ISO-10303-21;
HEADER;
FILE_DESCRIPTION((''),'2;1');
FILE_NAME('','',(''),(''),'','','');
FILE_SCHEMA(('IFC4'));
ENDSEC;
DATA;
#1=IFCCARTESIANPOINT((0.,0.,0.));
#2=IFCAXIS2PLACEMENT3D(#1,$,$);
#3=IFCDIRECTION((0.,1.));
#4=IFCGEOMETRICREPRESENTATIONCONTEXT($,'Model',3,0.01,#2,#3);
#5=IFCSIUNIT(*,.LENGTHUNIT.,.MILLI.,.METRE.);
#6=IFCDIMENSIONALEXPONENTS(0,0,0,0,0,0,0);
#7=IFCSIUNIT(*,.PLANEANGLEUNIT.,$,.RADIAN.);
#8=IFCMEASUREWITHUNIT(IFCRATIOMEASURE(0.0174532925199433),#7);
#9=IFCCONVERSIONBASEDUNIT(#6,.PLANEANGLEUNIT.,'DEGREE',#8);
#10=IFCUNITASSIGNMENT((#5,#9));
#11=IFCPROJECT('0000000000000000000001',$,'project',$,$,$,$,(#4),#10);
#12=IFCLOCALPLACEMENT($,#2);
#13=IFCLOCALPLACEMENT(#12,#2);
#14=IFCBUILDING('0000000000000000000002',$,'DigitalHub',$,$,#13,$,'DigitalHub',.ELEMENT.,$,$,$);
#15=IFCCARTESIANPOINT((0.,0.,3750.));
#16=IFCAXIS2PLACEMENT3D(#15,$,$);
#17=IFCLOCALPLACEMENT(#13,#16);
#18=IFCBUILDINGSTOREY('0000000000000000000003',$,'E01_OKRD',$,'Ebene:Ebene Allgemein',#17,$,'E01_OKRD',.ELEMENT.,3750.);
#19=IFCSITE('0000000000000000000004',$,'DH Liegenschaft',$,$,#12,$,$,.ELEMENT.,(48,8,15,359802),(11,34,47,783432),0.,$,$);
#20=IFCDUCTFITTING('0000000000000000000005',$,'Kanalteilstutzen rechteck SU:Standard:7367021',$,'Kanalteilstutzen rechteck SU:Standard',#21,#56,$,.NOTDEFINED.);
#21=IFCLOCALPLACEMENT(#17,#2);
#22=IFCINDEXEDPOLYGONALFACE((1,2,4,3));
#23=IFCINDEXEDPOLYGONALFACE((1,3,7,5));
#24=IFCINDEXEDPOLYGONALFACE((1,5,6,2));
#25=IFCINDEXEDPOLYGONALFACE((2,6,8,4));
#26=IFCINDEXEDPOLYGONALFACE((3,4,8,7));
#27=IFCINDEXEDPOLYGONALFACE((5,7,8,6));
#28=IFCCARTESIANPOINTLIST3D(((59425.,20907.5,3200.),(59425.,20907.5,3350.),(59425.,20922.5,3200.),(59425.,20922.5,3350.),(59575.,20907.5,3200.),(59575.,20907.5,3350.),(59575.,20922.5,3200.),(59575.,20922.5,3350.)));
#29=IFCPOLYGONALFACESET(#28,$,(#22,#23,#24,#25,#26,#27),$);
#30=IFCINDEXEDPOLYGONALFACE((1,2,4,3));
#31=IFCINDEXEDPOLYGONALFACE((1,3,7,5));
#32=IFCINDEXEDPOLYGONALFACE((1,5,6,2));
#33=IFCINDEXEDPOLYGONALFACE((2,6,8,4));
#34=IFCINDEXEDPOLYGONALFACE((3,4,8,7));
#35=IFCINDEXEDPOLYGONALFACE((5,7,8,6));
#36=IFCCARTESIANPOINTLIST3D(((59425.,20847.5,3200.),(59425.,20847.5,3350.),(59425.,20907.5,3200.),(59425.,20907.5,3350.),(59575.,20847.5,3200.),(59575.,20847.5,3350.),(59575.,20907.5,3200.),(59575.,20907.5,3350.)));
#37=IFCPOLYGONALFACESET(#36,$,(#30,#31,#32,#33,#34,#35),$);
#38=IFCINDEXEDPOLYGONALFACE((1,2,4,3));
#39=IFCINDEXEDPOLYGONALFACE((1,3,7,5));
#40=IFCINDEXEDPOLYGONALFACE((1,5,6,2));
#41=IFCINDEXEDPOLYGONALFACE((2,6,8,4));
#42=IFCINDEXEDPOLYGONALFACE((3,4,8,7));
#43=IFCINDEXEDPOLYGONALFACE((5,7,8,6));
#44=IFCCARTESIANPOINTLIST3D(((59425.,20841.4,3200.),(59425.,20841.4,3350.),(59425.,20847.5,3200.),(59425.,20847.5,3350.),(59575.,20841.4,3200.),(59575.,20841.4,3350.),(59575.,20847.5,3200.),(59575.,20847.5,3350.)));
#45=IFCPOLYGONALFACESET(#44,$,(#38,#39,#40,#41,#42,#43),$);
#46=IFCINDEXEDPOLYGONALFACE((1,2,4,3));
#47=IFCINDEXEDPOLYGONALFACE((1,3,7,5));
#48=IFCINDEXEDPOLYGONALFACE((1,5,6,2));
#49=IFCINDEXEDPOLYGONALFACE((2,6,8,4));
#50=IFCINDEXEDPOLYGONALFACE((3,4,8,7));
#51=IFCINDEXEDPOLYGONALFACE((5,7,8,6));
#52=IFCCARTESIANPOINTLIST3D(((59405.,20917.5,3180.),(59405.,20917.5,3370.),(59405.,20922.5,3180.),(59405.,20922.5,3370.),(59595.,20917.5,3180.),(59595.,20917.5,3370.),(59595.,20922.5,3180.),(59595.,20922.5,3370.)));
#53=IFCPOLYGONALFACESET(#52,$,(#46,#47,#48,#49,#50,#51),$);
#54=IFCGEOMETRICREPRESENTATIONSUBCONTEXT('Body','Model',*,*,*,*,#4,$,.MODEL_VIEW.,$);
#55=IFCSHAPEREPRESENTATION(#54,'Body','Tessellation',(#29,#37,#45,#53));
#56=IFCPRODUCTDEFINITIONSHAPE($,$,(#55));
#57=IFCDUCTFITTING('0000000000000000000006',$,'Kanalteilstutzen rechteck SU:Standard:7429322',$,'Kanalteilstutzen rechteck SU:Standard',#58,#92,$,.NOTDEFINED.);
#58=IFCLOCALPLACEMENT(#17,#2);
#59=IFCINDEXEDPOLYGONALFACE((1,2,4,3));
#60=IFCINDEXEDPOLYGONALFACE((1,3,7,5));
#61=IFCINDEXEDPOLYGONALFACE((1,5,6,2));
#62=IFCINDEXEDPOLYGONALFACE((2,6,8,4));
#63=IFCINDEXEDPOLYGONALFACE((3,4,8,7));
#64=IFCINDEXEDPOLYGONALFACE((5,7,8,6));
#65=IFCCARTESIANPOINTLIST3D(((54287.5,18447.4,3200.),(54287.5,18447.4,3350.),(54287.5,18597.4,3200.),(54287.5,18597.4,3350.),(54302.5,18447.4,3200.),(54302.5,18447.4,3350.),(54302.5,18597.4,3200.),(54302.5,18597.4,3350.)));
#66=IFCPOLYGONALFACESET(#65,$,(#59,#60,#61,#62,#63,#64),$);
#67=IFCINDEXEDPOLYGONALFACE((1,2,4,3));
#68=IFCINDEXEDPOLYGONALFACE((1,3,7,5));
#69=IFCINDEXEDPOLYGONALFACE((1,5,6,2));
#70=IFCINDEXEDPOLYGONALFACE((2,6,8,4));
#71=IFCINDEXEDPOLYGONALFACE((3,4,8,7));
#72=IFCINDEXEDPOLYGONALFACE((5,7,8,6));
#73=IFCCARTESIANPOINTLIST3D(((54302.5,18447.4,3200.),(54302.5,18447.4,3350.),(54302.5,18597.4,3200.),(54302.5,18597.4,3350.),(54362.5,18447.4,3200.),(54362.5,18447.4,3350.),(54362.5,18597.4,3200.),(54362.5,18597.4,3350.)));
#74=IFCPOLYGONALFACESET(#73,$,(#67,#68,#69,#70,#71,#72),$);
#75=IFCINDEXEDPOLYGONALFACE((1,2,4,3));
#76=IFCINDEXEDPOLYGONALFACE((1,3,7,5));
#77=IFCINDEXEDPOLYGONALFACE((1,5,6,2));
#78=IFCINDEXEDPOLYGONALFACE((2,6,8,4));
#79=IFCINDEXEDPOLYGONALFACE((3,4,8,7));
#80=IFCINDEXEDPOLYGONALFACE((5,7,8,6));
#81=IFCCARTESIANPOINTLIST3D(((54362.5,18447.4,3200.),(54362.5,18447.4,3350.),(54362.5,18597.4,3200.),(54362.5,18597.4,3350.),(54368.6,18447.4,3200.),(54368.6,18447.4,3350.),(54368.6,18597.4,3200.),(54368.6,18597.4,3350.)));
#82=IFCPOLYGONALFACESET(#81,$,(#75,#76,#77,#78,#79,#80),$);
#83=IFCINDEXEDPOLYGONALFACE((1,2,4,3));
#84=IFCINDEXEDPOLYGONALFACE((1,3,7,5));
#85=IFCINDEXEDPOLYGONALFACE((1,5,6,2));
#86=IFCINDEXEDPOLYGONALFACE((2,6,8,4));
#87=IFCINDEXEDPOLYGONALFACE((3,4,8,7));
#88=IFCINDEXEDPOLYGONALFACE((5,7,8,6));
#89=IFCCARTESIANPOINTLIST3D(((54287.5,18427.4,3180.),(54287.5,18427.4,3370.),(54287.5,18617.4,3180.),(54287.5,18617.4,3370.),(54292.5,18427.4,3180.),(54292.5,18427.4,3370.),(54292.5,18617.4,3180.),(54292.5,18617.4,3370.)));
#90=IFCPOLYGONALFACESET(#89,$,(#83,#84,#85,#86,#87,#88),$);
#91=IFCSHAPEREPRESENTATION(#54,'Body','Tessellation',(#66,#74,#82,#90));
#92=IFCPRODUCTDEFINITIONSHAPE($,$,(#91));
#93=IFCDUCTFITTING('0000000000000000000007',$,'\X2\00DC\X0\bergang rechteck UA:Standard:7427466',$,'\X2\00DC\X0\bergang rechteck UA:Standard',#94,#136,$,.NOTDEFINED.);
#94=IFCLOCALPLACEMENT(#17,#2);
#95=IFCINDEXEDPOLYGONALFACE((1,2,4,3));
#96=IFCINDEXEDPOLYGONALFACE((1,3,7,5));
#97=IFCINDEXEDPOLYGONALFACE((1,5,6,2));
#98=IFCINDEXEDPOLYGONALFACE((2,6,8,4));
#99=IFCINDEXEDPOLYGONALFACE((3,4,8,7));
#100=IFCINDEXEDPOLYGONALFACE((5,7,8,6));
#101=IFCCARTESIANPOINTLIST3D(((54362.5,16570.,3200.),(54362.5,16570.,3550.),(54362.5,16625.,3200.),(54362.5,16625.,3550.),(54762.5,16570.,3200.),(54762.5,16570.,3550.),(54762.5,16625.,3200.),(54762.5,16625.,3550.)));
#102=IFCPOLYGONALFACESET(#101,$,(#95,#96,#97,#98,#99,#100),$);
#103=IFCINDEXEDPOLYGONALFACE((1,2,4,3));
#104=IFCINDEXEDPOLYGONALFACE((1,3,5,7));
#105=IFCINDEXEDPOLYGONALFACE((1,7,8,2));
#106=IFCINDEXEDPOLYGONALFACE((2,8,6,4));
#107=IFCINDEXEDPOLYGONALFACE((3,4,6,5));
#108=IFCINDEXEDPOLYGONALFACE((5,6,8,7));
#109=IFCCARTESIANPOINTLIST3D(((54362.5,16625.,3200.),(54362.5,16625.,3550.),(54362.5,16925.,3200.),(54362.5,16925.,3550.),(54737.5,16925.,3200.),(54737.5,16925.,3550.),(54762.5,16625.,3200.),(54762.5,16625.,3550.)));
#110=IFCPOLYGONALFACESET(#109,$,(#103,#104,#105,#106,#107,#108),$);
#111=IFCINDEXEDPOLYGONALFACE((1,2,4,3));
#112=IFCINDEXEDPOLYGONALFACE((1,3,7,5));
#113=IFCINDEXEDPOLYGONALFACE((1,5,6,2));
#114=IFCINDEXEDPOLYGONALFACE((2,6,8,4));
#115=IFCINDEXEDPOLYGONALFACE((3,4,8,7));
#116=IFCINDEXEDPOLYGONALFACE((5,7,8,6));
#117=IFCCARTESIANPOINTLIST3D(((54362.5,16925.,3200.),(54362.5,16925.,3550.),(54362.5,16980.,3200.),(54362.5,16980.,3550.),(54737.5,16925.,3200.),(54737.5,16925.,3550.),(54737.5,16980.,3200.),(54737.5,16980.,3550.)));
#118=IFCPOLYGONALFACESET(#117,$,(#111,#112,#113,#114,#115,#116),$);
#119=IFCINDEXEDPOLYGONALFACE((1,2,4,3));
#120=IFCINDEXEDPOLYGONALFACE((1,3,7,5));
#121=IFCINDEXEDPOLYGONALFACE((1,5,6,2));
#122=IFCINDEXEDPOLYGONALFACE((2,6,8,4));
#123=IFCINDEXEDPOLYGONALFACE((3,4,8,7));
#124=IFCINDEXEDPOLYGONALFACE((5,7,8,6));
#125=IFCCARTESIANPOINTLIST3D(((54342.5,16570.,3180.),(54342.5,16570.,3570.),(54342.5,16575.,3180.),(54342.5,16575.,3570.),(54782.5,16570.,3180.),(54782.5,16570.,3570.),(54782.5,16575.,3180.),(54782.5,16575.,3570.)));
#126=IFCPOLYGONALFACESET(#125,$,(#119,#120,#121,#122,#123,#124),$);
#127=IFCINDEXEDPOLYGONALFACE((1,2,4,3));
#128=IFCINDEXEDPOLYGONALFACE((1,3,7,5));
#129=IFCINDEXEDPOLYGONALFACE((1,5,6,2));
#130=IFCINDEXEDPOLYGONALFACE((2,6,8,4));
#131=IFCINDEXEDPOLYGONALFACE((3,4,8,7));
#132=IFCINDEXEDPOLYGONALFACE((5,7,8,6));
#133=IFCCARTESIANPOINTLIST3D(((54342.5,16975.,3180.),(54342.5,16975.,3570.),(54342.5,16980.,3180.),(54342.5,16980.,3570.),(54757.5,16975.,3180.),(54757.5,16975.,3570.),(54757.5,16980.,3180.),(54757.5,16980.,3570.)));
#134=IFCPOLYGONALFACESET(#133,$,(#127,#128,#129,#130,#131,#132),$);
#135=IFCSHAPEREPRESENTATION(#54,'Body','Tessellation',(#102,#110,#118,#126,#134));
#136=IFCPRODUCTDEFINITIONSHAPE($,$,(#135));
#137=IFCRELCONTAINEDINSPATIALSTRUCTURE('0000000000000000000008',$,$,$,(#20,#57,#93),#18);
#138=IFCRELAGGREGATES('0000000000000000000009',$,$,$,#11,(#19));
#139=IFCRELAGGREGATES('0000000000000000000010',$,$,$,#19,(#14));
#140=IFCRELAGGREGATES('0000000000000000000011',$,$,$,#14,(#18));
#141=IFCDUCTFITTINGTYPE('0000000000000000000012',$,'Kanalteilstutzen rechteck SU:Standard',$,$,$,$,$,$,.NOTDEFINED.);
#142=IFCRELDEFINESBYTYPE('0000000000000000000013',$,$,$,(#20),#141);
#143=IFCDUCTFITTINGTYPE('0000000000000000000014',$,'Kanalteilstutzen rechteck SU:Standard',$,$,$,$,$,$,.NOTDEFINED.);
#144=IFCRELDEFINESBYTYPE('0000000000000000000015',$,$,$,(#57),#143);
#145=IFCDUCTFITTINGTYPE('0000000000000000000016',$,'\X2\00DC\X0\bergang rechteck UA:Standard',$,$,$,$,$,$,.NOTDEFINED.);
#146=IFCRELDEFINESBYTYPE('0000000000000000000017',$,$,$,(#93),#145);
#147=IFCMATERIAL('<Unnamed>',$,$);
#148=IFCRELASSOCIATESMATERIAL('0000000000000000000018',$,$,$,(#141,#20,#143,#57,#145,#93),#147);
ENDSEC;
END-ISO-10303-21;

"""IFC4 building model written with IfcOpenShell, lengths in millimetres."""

from ifc_helpers import new_model, entity, si_unit, converted_unit, direction, frame, origin, place, context, subcontext, project, spatial, indexed_curve, outline, extrude, source, transform, mapped, material, type_object, type_shapes, element, save


model = new_model("IFC4")

# Units and contexts
model_context = context("Model", 3, precision=0.01, world=origin(), true_north=direction((0.0, 1.0)))
body_context = subcontext(model_context, "Body", "Model", "MODEL_VIEW")
ifc_project = project(units=[si_unit("LENGTHUNIT", "METRE", prefix="MILLI"), converted_unit("PLANEANGLEUNIT", "DEGREE", entity("IfcRatioMeasure", 0.0174532925199433), si_unit("PLANEANGLEUNIT", "RADIAN"), dimensions=[0, 0, 0, 0, 0, 0, 0])], contexts=[model_context])

# Site, building, storey
site_placement = place(None, origin())
site = spatial("IfcSite", under=ifc_project, at=site_placement, Name="DH Liegenschaft", CompositionType="ELEMENT", RefLatitude=(48, 8, 15, 359802), RefLongitude=(11, 34, 47, 783432), RefElevation=0.0)
building_placement = place(site_placement, origin())
building = spatial("IfcBuilding", under=site, at=building_placement, Name="DigitalHub", LongName="DigitalHub", CompositionType="ELEMENT")
storey_placement = place(building_placement, frame((0.0, 0.0, 3750.0)))
storey = spatial("IfcBuildingStorey", under=building, at=storey_placement, Name="E01_OKRD", ObjectType="Ebene:Ebene Allgemein", LongName="E01_OKRD", CompositionType="ELEMENT", Elevation=3750.0)

# Shared definitions
ifc_material_1 = material(Name="<Unnamed>")

# Duct fittings
duct_fitting_type_1 = type_object("IfcDuctFittingType", Name="Kanalteilstutzen rechteck SU:Standard", PredefinedType="NOTDEFINED", material=ifc_material_1)
shared_shape_1 = source(origin(), body_context, "Body", "SweptSolid", [
    extrude(outline(indexed_curve([(-75.0, -7.5), (75.0, -7.5), (75.0, 7.5), (-75.0, 7.5), (-75.0, -7.5)], self_intersect=False)), frame((67.5, 0.0, -75.0), z_axis=(0.0, 0.0, 1.0), x_axis=(0.0, -1.0, 0.0)), (0.0, 0.0, 1.0), 150.0),
    extrude(outline(indexed_curve([(-75.0, -30.0), (75.0, -30.0), (75.0, 30.0), (-75.0, 30.0), (-75.0, -30.0)], self_intersect=False)), frame((30.0, 0.0, -75.0), z_axis=(0.0, 0.0, 1.0), x_axis=(0.0, -1.0, 0.0)), (0.0, 0.0, 1.0), 150.0),
    extrude(outline(indexed_curve([(-75.0, -3.0), (75.0, -3.0), (75.0, 3.0), (-75.0, 3.0), (-75.0, -3.0)], self_intersect=False)), frame((-3.0, 0.0, -75.0), z_axis=(0.0, 0.0, 1.0), x_axis=(0.0, -1.0, 0.0)), (0.0, 0.0, 1.0), 150.0),
    extrude(outline(indexed_curve([(-95.0, -2.5), (95.0, -2.5), (95.0, 2.5), (-95.0, 2.5), (-95.0, -2.5)], self_intersect=False)), frame((72.5, 0.0, -95.0), z_axis=(0.0, 0.0, 1.0), x_axis=(0.0, -1.0, 0.0)), (0.0, 0.0, 1.0), 190.0),
])
type_shapes(duct_fitting_type_1, [shared_shape_1])
duct_fitting_1_placement = place(storey_placement, frame((59500.0, 20847.5, 3275.0), z_axis=(0.0, 0.0, -1.0), x_axis=(0.0, 1.0, 0.0)))
element("IfcDuctFitting", 1, at=duct_fitting_1_placement, inside=storey, type_object=duct_fitting_type_1, material=ifc_material_1, Name="Kanalteilstutzen rechteck SU:Standard:7367021", ObjectType="Kanalteilstutzen rechteck SU:Standard", PredefinedType="NOTDEFINED", context=body_context, shape_type="MappedRepresentation", body=[
    mapped(shared_shape_1, transform((0.0, 0.0, 0.0), scale=1.0)),
])
duct_fitting_type_2 = type_object("IfcDuctFittingType", Name="Kanalteilstutzen rechteck SU:Standard", PredefinedType="NOTDEFINED", material=ifc_material_1)
shared_shape_2 = source(origin(), body_context, "Body", "SweptSolid", [
    extrude(outline(indexed_curve([(-7.5, -75.0), (7.5, -75.0), (7.5, 75.0), (-7.5, 75.0), (-7.5, -75.0)], self_intersect=False)), frame((67.5, 0.0, -75.0)), (0.0, 0.0, 1.0), 150.0),
    extrude(outline(indexed_curve([(-30.0, -75.0), (30.0, -75.0), (30.0, 75.0), (-30.0, 75.0), (-30.0, -75.0)], self_intersect=False)), frame((30.0, 0.0, -75.0)), (0.0, 0.0, 1.0), 150.0),
    extrude(outline(indexed_curve([(-3.0, -75.0), (3.0, -75.0), (3.0, 75.0), (-3.0, 75.0), (-3.0, -75.0)], self_intersect=False)), frame((-3.0, 0.0, -75.0)), (0.0, 0.0, 1.0), 150.0),
    extrude(outline(indexed_curve([(-2.5, -95.0), (2.5, -95.0), (2.5, 95.0), (-2.5, 95.0), (-2.5, -95.0)], self_intersect=False)), frame((72.5, 0.0, -95.0)), (0.0, 0.0, 1.0), 190.0),
])
type_shapes(duct_fitting_type_2, [shared_shape_2])
duct_fitting_2_placement = place(storey_placement, frame((54362.5, 18522.4, 3275.0), z_axis=(0.0, 0.0, -1.0), x_axis=(-1.0, 0.0, 0.0)))
element("IfcDuctFitting", 2, at=duct_fitting_2_placement, inside=storey, type_object=duct_fitting_type_2, material=ifc_material_1, Name="Kanalteilstutzen rechteck SU:Standard:7429322", ObjectType="Kanalteilstutzen rechteck SU:Standard", PredefinedType="NOTDEFINED", context=body_context, shape_type="MappedRepresentation", body=[
    mapped(shared_shape_2, transform((0.0, 0.0, 0.0), scale=1.0)),
])
duct_fitting_type_3 = type_object("IfcDuctFittingType", Name="Übergang rechteck UA:Standard", PredefinedType="NOTDEFINED", material=ifc_material_1)
shared_shape_3 = source(origin(), body_context, "Body", "SweptSolid", [
    extrude(outline(indexed_curve([(-27.5, -200.0), (27.5, -200.0), (27.5, 200.0), (-27.5, 200.0), (-27.5, -200.0)], self_intersect=False)), frame((382.5, 12.5, -175.0)), (0.0, 0.0, 1.0), 350.0),
    extrude(outline(indexed_curve([(-150.0, -193.8), (150.0, -193.8), (150.0, 206.2), (-150.0, 181.2), (-150.0, -193.8)], self_intersect=False)), frame((205.0, 6.2, -175.0)), (0.0, 0.0, 1.0), 350.0),
    extrude(outline(indexed_curve([(-27.5, -187.5), (27.5, -187.5), (27.5, 187.5), (-27.5, 187.5), (-27.5, -187.5)], self_intersect=False)), frame((27.5, 0.0, -175.0)), (0.0, 0.0, 1.0), 350.0),
    extrude(outline(indexed_curve([(-2.5, -220.0), (2.5, -220.0), (2.5, 220.0), (-2.5, 220.0), (-2.5, -220.0)], self_intersect=False)), frame((407.5, 12.5, -195.0)), (0.0, 0.0, 1.0), 390.0),
    extrude(outline(indexed_curve([(-2.5, -207.5), (2.5, -207.5), (2.5, 207.5), (-2.5, 207.5), (-2.5, -207.5)], self_intersect=False)), frame((2.5, 0.0, -195.0)), (0.0, 0.0, 1.0), 390.0),
])
type_shapes(duct_fitting_type_3, [shared_shape_3])
duct_fitting_3_placement = place(storey_placement, frame((54550.0, 16980.0, 3375.0), z_axis=(0.0, 0.0, 1.0), x_axis=(0.0, -1.0, 0.0)))
element("IfcDuctFitting", 3, at=duct_fitting_3_placement, inside=storey, type_object=duct_fitting_type_3, material=ifc_material_1, Name="Übergang rechteck UA:Standard:7427466", ObjectType="Übergang rechteck UA:Standard", PredefinedType="NOTDEFINED", context=body_context, shape_type="MappedRepresentation", body=[
    mapped(shared_shape_3, transform((0.0, 0.0, 0.0), scale=1.0)),
])

save(model, "model.ifc")
